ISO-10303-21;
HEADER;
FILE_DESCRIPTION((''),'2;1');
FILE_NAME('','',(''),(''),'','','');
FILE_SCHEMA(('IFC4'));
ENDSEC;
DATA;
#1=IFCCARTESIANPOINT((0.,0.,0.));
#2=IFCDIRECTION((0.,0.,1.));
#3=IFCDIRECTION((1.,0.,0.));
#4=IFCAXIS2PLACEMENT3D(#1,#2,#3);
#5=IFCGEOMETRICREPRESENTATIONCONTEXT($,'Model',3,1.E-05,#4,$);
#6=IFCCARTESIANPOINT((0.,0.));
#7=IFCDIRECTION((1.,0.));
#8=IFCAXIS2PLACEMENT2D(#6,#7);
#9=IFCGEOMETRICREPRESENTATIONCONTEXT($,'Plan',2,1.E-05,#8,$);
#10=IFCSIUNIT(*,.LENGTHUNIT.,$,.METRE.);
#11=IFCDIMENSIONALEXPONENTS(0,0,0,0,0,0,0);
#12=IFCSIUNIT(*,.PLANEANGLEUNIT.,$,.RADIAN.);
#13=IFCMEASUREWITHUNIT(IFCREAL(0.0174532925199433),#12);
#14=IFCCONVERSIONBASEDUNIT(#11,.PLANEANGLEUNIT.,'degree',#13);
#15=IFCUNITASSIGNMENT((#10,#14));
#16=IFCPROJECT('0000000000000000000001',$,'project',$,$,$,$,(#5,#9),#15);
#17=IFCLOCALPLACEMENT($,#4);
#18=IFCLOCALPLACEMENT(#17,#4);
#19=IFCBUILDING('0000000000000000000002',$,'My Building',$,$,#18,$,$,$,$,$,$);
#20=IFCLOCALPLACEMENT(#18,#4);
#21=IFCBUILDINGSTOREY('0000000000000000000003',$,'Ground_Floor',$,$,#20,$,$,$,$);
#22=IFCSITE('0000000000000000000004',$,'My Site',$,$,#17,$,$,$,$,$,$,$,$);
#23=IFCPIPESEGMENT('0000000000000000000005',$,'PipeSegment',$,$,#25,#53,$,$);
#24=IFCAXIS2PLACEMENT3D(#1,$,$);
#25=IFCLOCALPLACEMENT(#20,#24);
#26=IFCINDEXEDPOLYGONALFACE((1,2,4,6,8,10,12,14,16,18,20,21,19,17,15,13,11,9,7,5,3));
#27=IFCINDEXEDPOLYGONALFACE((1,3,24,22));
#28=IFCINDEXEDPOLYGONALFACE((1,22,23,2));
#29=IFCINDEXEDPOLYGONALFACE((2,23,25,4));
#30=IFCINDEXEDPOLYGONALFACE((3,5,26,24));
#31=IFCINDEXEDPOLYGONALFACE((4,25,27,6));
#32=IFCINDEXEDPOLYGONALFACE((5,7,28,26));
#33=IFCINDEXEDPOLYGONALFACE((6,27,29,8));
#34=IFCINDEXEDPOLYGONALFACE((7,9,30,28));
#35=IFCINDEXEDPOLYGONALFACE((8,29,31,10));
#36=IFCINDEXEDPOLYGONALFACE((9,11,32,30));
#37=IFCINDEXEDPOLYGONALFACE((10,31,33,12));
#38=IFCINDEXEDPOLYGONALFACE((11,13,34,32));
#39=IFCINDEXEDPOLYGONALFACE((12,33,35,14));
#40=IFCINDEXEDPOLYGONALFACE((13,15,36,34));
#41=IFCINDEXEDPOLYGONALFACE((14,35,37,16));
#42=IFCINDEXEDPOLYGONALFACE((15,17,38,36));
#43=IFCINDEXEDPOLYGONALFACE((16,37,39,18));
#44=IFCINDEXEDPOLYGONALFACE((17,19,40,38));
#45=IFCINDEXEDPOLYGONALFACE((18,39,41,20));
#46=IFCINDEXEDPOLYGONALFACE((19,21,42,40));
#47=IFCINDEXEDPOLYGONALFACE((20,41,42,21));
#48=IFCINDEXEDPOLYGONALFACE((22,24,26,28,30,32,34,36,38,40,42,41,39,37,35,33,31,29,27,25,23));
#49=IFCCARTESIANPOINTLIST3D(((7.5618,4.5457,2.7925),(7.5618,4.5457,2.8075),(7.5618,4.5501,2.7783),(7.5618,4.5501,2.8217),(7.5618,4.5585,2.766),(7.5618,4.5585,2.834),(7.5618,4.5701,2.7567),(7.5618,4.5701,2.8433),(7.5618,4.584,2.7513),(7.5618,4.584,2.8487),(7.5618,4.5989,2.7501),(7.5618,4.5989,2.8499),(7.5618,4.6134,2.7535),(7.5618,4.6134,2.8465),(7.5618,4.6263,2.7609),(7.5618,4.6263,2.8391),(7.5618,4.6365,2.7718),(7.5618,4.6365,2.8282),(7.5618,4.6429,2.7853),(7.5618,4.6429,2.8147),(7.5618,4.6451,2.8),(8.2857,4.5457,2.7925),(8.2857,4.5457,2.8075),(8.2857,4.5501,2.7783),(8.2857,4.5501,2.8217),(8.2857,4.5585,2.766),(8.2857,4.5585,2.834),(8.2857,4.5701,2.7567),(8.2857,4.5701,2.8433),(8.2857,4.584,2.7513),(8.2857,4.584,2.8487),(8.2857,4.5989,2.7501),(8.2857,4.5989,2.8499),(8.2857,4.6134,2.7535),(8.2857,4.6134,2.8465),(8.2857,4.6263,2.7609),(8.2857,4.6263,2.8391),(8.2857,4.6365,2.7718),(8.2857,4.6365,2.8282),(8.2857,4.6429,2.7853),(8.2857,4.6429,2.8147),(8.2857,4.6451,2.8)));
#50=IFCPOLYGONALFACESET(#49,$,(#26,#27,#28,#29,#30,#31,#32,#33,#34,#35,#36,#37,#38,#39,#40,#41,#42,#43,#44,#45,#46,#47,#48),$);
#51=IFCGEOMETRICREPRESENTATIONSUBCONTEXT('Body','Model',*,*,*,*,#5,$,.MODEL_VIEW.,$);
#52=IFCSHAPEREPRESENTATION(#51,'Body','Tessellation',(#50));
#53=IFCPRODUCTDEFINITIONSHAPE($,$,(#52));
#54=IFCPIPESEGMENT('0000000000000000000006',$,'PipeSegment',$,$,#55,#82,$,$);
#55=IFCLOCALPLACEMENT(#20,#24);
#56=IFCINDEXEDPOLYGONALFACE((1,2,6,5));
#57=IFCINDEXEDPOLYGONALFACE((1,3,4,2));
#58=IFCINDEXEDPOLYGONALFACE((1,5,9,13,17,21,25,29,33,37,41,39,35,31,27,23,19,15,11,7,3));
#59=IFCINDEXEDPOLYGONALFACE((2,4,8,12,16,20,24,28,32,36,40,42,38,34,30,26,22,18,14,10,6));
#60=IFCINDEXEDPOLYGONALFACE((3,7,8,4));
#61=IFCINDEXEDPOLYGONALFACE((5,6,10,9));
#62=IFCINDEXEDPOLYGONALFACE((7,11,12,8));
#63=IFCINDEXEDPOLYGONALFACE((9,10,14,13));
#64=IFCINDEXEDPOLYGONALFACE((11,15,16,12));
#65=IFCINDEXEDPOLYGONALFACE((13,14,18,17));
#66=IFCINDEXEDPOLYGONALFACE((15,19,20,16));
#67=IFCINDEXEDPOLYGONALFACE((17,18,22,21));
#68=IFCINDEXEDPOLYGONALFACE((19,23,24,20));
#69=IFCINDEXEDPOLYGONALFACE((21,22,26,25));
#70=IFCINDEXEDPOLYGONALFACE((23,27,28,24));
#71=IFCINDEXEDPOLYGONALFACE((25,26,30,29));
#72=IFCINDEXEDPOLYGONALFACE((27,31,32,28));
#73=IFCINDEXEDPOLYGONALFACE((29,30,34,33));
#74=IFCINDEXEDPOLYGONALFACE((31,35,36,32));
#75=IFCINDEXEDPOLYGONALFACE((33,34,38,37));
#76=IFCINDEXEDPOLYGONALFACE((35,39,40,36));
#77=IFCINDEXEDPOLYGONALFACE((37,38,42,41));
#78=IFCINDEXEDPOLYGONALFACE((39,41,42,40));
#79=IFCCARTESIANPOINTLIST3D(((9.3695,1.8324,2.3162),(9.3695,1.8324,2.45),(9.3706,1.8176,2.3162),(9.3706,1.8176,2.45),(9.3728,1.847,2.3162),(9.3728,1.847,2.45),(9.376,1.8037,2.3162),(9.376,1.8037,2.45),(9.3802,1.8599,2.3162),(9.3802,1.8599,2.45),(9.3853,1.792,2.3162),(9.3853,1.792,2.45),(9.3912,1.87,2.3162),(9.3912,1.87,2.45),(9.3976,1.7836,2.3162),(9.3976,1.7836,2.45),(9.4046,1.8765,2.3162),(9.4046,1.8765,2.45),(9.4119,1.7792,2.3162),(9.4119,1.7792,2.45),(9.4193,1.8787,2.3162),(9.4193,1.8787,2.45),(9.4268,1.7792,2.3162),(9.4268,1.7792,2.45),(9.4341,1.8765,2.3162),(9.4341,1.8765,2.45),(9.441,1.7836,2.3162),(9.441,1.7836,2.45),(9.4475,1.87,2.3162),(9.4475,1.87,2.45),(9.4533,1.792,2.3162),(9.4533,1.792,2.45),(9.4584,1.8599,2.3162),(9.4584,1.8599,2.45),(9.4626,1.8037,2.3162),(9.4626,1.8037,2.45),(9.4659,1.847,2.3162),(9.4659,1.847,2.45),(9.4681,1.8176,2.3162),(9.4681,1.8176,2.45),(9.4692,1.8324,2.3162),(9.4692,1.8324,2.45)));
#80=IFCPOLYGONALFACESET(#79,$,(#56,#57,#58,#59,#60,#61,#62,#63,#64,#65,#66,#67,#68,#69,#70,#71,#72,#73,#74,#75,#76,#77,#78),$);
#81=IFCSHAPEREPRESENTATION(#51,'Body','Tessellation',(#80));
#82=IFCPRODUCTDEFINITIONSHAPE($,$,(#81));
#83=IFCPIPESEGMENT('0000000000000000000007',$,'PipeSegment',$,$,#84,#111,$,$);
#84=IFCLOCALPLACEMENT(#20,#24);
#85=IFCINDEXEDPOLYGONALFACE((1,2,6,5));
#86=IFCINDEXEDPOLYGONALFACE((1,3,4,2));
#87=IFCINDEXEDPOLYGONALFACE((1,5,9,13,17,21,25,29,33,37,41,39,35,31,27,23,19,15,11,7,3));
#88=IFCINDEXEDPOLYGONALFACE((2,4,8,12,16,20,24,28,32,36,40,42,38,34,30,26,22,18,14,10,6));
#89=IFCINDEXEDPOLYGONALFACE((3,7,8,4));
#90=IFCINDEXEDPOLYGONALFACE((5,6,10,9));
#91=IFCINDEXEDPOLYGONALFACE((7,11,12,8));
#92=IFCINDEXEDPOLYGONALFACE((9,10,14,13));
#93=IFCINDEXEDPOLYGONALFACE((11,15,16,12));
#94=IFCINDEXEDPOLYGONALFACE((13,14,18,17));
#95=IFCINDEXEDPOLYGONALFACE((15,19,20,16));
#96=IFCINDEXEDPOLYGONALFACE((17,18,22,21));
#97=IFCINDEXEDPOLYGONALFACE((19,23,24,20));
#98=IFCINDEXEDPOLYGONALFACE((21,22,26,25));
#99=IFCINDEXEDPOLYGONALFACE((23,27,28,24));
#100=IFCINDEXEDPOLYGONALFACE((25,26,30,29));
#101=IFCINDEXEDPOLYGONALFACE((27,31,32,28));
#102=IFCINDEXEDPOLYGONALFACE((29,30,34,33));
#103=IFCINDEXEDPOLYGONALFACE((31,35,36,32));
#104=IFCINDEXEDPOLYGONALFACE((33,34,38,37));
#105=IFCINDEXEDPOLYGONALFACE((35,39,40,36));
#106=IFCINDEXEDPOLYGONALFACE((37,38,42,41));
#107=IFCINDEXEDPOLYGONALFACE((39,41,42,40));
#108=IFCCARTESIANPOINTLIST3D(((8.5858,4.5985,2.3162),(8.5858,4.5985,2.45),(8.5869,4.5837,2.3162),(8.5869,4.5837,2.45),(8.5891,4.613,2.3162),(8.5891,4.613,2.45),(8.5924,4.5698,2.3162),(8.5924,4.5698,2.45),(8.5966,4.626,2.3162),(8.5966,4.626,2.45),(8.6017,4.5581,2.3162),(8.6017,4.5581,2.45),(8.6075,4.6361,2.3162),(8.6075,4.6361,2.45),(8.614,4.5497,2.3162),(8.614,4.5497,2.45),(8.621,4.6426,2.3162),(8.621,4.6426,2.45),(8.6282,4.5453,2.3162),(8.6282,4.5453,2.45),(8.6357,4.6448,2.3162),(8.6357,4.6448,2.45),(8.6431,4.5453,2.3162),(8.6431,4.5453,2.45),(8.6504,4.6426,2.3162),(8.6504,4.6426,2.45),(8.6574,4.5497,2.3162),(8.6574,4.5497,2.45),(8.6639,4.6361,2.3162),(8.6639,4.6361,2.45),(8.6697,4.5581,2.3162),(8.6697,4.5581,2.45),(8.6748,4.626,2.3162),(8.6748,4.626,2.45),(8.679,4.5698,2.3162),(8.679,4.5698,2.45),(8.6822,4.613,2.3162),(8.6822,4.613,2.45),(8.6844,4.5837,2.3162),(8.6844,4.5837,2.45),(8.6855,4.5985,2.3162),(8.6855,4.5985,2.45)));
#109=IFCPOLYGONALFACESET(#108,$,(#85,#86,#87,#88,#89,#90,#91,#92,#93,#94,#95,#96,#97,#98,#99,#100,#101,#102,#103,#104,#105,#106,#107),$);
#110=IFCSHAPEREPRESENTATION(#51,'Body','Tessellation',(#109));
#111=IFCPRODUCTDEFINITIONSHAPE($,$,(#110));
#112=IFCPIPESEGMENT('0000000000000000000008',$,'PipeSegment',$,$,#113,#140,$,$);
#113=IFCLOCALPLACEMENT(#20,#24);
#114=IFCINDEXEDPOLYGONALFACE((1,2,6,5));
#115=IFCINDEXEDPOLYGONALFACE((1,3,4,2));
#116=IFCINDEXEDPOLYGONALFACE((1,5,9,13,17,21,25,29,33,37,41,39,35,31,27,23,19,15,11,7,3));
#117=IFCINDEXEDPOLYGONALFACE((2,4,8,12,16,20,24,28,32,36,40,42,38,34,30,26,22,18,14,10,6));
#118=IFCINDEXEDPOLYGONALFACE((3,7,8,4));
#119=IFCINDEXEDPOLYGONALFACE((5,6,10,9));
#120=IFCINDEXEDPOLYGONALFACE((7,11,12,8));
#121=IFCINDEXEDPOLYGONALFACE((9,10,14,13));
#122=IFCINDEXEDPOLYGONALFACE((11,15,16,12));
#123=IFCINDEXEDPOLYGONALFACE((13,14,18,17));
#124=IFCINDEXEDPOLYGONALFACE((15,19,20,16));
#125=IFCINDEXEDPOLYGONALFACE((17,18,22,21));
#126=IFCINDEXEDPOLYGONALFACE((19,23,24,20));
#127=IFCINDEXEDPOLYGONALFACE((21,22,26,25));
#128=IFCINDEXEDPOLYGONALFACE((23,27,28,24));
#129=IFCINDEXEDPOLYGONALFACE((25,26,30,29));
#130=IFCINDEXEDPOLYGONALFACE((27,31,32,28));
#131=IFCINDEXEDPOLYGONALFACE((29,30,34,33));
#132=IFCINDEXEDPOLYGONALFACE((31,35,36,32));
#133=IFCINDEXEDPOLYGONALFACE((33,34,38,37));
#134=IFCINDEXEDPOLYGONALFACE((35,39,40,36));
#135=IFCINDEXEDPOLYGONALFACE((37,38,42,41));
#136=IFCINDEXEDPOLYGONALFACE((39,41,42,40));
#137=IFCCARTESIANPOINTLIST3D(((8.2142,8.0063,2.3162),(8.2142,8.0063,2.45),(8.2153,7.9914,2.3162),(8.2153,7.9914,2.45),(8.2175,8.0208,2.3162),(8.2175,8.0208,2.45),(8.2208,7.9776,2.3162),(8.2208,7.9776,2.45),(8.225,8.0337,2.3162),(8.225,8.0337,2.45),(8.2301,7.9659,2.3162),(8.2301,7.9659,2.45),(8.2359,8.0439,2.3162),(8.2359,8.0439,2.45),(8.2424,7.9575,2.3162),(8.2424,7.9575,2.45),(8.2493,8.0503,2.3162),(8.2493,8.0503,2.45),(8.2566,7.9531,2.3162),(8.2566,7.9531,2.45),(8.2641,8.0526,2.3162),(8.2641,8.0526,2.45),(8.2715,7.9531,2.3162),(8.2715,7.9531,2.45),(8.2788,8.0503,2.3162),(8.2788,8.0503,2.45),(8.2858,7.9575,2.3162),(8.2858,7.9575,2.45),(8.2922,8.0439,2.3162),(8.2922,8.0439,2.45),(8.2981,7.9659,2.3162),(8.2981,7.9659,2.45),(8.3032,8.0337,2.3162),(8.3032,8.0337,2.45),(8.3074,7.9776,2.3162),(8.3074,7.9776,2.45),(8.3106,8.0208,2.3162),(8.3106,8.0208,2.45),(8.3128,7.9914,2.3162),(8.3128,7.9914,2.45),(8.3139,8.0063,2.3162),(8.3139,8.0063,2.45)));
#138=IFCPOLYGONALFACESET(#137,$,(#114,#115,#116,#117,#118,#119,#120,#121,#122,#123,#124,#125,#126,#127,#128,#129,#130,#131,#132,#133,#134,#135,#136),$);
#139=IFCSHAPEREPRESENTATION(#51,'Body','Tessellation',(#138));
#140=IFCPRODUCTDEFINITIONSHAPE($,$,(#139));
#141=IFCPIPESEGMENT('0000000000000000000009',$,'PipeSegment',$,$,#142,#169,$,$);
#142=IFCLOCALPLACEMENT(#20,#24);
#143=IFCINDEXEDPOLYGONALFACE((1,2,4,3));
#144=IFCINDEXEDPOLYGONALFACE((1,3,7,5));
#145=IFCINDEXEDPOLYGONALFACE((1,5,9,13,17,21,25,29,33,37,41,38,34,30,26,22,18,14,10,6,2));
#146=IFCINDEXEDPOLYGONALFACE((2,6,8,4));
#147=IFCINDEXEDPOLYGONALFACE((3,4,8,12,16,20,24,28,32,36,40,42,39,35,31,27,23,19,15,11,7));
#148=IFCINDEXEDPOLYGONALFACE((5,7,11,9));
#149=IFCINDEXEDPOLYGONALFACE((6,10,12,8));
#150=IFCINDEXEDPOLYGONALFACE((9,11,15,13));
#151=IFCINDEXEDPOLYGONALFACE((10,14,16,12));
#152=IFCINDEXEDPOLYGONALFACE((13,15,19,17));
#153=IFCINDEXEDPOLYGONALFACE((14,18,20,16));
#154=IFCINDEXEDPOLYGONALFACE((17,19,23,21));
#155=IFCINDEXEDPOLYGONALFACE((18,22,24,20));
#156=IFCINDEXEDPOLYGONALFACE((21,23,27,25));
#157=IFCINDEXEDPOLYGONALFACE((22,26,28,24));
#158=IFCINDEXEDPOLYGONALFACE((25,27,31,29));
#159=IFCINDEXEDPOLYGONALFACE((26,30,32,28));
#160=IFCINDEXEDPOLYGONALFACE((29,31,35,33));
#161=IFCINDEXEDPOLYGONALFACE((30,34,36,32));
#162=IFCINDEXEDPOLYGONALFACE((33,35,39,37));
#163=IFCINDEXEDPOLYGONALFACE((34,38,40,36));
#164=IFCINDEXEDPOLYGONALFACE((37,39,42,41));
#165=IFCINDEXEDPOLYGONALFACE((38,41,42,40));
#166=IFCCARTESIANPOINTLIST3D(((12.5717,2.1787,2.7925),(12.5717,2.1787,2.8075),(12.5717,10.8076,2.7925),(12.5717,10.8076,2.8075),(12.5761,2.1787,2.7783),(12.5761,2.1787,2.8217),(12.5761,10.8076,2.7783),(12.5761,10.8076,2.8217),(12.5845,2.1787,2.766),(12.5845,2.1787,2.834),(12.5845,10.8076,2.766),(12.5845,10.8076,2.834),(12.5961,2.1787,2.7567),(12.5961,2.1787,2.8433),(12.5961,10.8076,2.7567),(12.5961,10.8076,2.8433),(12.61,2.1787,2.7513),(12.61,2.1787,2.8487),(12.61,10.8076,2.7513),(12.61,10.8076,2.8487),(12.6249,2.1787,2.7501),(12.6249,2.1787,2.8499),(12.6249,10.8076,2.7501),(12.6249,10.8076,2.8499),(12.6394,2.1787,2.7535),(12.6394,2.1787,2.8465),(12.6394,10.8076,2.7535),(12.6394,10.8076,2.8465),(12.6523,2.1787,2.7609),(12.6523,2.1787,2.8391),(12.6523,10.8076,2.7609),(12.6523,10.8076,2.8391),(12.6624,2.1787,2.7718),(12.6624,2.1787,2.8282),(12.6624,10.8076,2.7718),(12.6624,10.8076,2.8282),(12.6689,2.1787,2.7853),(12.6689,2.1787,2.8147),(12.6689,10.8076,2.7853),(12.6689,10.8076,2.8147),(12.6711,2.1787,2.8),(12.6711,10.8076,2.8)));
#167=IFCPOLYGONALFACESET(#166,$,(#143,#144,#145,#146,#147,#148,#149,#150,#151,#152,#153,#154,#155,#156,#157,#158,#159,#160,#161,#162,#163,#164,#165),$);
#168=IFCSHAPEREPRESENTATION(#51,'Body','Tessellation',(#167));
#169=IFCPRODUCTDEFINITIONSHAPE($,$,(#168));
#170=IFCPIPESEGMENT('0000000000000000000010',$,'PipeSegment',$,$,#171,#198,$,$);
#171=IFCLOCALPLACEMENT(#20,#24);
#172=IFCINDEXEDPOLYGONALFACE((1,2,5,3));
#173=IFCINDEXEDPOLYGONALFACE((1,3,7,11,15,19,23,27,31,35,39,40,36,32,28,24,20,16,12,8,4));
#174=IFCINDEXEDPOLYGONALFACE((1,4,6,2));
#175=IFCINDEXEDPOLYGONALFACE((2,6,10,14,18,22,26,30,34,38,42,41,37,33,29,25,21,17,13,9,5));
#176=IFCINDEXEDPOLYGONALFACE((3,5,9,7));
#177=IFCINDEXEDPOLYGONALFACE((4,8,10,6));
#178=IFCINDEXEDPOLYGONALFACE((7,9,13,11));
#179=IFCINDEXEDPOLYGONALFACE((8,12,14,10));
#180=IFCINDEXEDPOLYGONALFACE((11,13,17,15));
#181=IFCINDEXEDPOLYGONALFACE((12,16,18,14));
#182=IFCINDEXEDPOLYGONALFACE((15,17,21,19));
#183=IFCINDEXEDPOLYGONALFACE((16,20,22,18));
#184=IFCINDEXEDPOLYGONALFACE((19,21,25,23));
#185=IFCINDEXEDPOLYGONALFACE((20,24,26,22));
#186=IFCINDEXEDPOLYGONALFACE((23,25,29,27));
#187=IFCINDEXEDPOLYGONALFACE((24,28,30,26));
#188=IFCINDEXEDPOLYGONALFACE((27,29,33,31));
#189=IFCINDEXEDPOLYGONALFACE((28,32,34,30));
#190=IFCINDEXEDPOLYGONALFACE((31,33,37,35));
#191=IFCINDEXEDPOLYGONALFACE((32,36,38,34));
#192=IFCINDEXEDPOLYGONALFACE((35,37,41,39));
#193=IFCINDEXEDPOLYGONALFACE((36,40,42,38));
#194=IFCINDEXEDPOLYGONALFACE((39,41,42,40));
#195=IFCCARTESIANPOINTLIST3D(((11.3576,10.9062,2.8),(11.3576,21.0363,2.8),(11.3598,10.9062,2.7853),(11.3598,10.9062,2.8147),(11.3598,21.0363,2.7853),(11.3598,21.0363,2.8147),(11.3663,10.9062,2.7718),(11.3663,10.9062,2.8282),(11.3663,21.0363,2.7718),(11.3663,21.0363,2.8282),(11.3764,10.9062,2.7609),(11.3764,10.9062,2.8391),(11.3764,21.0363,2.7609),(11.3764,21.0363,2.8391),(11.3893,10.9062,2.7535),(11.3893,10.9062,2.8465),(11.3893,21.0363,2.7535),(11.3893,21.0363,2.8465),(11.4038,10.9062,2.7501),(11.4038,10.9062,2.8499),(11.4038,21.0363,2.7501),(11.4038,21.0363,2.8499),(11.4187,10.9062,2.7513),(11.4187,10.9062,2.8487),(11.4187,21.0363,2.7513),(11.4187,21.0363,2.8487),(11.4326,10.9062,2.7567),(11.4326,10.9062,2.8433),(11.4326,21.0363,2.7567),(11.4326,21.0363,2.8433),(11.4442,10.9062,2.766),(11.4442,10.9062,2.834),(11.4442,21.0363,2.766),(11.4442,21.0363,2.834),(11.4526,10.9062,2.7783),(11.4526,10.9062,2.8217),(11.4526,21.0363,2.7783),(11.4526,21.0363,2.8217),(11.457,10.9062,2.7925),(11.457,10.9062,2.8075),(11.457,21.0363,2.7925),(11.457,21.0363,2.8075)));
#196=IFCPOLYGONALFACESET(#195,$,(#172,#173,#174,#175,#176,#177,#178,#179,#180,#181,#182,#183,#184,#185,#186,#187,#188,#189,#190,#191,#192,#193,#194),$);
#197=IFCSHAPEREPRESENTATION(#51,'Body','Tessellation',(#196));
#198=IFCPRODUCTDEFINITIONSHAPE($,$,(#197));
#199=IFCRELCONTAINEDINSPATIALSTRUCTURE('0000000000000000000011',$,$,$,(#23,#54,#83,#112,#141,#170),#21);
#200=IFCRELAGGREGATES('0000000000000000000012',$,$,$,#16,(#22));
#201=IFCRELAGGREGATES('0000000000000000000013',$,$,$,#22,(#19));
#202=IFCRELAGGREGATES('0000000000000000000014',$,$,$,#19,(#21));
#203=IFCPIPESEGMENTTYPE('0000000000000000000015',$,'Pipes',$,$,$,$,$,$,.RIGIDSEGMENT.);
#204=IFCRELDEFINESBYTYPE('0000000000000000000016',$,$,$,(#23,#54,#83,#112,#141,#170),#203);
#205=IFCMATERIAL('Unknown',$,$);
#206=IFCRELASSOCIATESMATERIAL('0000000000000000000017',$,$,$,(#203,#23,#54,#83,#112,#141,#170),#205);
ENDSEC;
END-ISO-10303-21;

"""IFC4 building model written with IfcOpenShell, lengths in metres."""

from ifc_helpers import new_model, entity, si_unit, converted_unit, frame, origin_with_axes, origin_2d_with_axis, place, context, subcontext, project, spatial, circle, extrude, material, material_profile, profile_set, profile_usage, type_object, element, save


model = new_model("IFC4")

# Units and contexts
model_context = context("Model", 3, precision=1e-05, world=origin_with_axes())
plan_context = context("Plan", 2, precision=1e-05, world=origin_2d_with_axis())
body_context = subcontext(model_context, "Body", "Model", "MODEL_VIEW")
ifc_project = project(units=[si_unit("LENGTHUNIT", "METRE"), converted_unit("PLANEANGLEUNIT", "degree", entity("IfcReal", 0.0174532925199433), si_unit("PLANEANGLEUNIT", "RADIAN"), dimensions=[0, 0, 0, 0, 0, 0, 0])], contexts=[model_context, plan_context])

# Site, building, storey
site_placement = place(None, origin_with_axes())
site = spatial("IfcSite", under=ifc_project, at=site_placement, Name="My Site")
building_placement = place(site_placement, origin_with_axes())
building = spatial("IfcBuilding", under=site, at=building_placement, Name="My Building")
storey_placement = place(building_placement, origin_with_axes())
storey = spatial("IfcBuildingStorey", under=building, at=storey_placement, Name="Ground_Floor")

# Shared definitions
ifc_material = material(Name="Unknown")

# Pipe segments
ifc_material_profile_1 = material_profile(ifc_material, circle(Radius=0.05))
ifc_profile_set_1 = profile_set([ifc_material_profile_1])
pipe_segment_type = type_object("IfcPipeSegmentType", Name="Pipes", PredefinedType="RIGIDSEGMENT", material=ifc_profile_set_1)
ifc_profile_usage_1 = profile_usage(ifc_profile_set_1, cardinal=5)
pipe_segment_1_placement = place(storey_placement, frame((7.5618, 4.5951, 2.8), z_axis=(1.0, 0.0, 0.0), x_axis=(0.0, 1.0, 0.0)))
element("IfcPipeSegment", 1, at=pipe_segment_1_placement, inside=storey, type_object=pipe_segment_type, material=ifc_profile_usage_1, Name="PipeSegment", context=body_context, shape_type="SweptSolid", body=[
    extrude(circle(Radius=0.05), origin_with_axes(), (0.0, 0.0, 1.0), 0.7239),
])
ifc_profile_usage_2 = profile_usage(ifc_profile_set_1, cardinal=5)
pipe_segment_2_placement = place(storey_placement, frame((9.4193, 1.8287, 2.45), z_axis=(0.0, 0.0, -1.0), x_axis=(0.0, 1.0, 0.0)))
element("IfcPipeSegment", 2, at=pipe_segment_2_placement, inside=storey, type_object=pipe_segment_type, material=ifc_profile_usage_2, Name="PipeSegment", context=body_context, shape_type="SweptSolid", body=[
    extrude(circle(Radius=0.05), origin_with_axes(), (0.0, 0.0, 1.0), 0.1338),
])
ifc_profile_usage_3 = profile_usage(ifc_profile_set_1, cardinal=5)
pipe_segment_3_placement = place(storey_placement, frame((8.6357, 4.5948, 2.45), z_axis=(0.0, 0.0, -1.0), x_axis=(0.0, 1.0, 0.0)))
element("IfcPipeSegment", 3, at=pipe_segment_3_placement, inside=storey, type_object=pipe_segment_type, material=ifc_profile_usage_3, Name="PipeSegment", context=body_context, shape_type="SweptSolid", body=[
    extrude(circle(Radius=0.05), origin_with_axes(), (0.0, 0.0, 1.0), 0.1338),
])
ifc_profile_usage_4 = profile_usage(ifc_profile_set_1, cardinal=5)
pipe_segment_4_placement = place(storey_placement, frame((8.2641, 8.0026, 2.45), z_axis=(0.0, 0.0, -1.0), x_axis=(0.0, 1.0, 0.0)))
element("IfcPipeSegment", 4, at=pipe_segment_4_placement, inside=storey, type_object=pipe_segment_type, material=ifc_profile_usage_4, Name="PipeSegment", context=body_context, shape_type="SweptSolid", body=[
    extrude(circle(Radius=0.05), origin_with_axes(), (0.0, 0.0, 1.0), 0.1338),
])
ifc_profile_usage_5 = profile_usage(ifc_profile_set_1, cardinal=5)
pipe_segment_5_placement = place(storey_placement, frame((12.6211, 10.8076, 2.8), z_axis=(0.0, -1.0, 0.0), x_axis=(1.0, 0.0, 0.0)))
element("IfcPipeSegment", 5, at=pipe_segment_5_placement, inside=storey, type_object=pipe_segment_type, material=ifc_profile_usage_5, Name="PipeSegment", context=body_context, shape_type="SweptSolid", body=[
    extrude(circle(Radius=0.05), origin_with_axes(), (0.0, 0.0, 1.0), 8.629),
])
ifc_profile_usage_6 = profile_usage(ifc_profile_set_1, cardinal=5)
pipe_segment_6_placement = place(storey_placement, frame((11.4076, 10.9062, 2.8), z_axis=(0.0, 1.0, 0.0), x_axis=(-1.0, 0.0, 0.0)))
element("IfcPipeSegment", 6, at=pipe_segment_6_placement, inside=storey, type_object=pipe_segment_type, material=ifc_profile_usage_6, Name="PipeSegment", context=body_context, shape_type="SweptSolid", body=[
    extrude(circle(Radius=0.05), origin_with_axes(), (0.0, 0.0, 1.0), 10.1301),
])

save(model, "model.ifc")
